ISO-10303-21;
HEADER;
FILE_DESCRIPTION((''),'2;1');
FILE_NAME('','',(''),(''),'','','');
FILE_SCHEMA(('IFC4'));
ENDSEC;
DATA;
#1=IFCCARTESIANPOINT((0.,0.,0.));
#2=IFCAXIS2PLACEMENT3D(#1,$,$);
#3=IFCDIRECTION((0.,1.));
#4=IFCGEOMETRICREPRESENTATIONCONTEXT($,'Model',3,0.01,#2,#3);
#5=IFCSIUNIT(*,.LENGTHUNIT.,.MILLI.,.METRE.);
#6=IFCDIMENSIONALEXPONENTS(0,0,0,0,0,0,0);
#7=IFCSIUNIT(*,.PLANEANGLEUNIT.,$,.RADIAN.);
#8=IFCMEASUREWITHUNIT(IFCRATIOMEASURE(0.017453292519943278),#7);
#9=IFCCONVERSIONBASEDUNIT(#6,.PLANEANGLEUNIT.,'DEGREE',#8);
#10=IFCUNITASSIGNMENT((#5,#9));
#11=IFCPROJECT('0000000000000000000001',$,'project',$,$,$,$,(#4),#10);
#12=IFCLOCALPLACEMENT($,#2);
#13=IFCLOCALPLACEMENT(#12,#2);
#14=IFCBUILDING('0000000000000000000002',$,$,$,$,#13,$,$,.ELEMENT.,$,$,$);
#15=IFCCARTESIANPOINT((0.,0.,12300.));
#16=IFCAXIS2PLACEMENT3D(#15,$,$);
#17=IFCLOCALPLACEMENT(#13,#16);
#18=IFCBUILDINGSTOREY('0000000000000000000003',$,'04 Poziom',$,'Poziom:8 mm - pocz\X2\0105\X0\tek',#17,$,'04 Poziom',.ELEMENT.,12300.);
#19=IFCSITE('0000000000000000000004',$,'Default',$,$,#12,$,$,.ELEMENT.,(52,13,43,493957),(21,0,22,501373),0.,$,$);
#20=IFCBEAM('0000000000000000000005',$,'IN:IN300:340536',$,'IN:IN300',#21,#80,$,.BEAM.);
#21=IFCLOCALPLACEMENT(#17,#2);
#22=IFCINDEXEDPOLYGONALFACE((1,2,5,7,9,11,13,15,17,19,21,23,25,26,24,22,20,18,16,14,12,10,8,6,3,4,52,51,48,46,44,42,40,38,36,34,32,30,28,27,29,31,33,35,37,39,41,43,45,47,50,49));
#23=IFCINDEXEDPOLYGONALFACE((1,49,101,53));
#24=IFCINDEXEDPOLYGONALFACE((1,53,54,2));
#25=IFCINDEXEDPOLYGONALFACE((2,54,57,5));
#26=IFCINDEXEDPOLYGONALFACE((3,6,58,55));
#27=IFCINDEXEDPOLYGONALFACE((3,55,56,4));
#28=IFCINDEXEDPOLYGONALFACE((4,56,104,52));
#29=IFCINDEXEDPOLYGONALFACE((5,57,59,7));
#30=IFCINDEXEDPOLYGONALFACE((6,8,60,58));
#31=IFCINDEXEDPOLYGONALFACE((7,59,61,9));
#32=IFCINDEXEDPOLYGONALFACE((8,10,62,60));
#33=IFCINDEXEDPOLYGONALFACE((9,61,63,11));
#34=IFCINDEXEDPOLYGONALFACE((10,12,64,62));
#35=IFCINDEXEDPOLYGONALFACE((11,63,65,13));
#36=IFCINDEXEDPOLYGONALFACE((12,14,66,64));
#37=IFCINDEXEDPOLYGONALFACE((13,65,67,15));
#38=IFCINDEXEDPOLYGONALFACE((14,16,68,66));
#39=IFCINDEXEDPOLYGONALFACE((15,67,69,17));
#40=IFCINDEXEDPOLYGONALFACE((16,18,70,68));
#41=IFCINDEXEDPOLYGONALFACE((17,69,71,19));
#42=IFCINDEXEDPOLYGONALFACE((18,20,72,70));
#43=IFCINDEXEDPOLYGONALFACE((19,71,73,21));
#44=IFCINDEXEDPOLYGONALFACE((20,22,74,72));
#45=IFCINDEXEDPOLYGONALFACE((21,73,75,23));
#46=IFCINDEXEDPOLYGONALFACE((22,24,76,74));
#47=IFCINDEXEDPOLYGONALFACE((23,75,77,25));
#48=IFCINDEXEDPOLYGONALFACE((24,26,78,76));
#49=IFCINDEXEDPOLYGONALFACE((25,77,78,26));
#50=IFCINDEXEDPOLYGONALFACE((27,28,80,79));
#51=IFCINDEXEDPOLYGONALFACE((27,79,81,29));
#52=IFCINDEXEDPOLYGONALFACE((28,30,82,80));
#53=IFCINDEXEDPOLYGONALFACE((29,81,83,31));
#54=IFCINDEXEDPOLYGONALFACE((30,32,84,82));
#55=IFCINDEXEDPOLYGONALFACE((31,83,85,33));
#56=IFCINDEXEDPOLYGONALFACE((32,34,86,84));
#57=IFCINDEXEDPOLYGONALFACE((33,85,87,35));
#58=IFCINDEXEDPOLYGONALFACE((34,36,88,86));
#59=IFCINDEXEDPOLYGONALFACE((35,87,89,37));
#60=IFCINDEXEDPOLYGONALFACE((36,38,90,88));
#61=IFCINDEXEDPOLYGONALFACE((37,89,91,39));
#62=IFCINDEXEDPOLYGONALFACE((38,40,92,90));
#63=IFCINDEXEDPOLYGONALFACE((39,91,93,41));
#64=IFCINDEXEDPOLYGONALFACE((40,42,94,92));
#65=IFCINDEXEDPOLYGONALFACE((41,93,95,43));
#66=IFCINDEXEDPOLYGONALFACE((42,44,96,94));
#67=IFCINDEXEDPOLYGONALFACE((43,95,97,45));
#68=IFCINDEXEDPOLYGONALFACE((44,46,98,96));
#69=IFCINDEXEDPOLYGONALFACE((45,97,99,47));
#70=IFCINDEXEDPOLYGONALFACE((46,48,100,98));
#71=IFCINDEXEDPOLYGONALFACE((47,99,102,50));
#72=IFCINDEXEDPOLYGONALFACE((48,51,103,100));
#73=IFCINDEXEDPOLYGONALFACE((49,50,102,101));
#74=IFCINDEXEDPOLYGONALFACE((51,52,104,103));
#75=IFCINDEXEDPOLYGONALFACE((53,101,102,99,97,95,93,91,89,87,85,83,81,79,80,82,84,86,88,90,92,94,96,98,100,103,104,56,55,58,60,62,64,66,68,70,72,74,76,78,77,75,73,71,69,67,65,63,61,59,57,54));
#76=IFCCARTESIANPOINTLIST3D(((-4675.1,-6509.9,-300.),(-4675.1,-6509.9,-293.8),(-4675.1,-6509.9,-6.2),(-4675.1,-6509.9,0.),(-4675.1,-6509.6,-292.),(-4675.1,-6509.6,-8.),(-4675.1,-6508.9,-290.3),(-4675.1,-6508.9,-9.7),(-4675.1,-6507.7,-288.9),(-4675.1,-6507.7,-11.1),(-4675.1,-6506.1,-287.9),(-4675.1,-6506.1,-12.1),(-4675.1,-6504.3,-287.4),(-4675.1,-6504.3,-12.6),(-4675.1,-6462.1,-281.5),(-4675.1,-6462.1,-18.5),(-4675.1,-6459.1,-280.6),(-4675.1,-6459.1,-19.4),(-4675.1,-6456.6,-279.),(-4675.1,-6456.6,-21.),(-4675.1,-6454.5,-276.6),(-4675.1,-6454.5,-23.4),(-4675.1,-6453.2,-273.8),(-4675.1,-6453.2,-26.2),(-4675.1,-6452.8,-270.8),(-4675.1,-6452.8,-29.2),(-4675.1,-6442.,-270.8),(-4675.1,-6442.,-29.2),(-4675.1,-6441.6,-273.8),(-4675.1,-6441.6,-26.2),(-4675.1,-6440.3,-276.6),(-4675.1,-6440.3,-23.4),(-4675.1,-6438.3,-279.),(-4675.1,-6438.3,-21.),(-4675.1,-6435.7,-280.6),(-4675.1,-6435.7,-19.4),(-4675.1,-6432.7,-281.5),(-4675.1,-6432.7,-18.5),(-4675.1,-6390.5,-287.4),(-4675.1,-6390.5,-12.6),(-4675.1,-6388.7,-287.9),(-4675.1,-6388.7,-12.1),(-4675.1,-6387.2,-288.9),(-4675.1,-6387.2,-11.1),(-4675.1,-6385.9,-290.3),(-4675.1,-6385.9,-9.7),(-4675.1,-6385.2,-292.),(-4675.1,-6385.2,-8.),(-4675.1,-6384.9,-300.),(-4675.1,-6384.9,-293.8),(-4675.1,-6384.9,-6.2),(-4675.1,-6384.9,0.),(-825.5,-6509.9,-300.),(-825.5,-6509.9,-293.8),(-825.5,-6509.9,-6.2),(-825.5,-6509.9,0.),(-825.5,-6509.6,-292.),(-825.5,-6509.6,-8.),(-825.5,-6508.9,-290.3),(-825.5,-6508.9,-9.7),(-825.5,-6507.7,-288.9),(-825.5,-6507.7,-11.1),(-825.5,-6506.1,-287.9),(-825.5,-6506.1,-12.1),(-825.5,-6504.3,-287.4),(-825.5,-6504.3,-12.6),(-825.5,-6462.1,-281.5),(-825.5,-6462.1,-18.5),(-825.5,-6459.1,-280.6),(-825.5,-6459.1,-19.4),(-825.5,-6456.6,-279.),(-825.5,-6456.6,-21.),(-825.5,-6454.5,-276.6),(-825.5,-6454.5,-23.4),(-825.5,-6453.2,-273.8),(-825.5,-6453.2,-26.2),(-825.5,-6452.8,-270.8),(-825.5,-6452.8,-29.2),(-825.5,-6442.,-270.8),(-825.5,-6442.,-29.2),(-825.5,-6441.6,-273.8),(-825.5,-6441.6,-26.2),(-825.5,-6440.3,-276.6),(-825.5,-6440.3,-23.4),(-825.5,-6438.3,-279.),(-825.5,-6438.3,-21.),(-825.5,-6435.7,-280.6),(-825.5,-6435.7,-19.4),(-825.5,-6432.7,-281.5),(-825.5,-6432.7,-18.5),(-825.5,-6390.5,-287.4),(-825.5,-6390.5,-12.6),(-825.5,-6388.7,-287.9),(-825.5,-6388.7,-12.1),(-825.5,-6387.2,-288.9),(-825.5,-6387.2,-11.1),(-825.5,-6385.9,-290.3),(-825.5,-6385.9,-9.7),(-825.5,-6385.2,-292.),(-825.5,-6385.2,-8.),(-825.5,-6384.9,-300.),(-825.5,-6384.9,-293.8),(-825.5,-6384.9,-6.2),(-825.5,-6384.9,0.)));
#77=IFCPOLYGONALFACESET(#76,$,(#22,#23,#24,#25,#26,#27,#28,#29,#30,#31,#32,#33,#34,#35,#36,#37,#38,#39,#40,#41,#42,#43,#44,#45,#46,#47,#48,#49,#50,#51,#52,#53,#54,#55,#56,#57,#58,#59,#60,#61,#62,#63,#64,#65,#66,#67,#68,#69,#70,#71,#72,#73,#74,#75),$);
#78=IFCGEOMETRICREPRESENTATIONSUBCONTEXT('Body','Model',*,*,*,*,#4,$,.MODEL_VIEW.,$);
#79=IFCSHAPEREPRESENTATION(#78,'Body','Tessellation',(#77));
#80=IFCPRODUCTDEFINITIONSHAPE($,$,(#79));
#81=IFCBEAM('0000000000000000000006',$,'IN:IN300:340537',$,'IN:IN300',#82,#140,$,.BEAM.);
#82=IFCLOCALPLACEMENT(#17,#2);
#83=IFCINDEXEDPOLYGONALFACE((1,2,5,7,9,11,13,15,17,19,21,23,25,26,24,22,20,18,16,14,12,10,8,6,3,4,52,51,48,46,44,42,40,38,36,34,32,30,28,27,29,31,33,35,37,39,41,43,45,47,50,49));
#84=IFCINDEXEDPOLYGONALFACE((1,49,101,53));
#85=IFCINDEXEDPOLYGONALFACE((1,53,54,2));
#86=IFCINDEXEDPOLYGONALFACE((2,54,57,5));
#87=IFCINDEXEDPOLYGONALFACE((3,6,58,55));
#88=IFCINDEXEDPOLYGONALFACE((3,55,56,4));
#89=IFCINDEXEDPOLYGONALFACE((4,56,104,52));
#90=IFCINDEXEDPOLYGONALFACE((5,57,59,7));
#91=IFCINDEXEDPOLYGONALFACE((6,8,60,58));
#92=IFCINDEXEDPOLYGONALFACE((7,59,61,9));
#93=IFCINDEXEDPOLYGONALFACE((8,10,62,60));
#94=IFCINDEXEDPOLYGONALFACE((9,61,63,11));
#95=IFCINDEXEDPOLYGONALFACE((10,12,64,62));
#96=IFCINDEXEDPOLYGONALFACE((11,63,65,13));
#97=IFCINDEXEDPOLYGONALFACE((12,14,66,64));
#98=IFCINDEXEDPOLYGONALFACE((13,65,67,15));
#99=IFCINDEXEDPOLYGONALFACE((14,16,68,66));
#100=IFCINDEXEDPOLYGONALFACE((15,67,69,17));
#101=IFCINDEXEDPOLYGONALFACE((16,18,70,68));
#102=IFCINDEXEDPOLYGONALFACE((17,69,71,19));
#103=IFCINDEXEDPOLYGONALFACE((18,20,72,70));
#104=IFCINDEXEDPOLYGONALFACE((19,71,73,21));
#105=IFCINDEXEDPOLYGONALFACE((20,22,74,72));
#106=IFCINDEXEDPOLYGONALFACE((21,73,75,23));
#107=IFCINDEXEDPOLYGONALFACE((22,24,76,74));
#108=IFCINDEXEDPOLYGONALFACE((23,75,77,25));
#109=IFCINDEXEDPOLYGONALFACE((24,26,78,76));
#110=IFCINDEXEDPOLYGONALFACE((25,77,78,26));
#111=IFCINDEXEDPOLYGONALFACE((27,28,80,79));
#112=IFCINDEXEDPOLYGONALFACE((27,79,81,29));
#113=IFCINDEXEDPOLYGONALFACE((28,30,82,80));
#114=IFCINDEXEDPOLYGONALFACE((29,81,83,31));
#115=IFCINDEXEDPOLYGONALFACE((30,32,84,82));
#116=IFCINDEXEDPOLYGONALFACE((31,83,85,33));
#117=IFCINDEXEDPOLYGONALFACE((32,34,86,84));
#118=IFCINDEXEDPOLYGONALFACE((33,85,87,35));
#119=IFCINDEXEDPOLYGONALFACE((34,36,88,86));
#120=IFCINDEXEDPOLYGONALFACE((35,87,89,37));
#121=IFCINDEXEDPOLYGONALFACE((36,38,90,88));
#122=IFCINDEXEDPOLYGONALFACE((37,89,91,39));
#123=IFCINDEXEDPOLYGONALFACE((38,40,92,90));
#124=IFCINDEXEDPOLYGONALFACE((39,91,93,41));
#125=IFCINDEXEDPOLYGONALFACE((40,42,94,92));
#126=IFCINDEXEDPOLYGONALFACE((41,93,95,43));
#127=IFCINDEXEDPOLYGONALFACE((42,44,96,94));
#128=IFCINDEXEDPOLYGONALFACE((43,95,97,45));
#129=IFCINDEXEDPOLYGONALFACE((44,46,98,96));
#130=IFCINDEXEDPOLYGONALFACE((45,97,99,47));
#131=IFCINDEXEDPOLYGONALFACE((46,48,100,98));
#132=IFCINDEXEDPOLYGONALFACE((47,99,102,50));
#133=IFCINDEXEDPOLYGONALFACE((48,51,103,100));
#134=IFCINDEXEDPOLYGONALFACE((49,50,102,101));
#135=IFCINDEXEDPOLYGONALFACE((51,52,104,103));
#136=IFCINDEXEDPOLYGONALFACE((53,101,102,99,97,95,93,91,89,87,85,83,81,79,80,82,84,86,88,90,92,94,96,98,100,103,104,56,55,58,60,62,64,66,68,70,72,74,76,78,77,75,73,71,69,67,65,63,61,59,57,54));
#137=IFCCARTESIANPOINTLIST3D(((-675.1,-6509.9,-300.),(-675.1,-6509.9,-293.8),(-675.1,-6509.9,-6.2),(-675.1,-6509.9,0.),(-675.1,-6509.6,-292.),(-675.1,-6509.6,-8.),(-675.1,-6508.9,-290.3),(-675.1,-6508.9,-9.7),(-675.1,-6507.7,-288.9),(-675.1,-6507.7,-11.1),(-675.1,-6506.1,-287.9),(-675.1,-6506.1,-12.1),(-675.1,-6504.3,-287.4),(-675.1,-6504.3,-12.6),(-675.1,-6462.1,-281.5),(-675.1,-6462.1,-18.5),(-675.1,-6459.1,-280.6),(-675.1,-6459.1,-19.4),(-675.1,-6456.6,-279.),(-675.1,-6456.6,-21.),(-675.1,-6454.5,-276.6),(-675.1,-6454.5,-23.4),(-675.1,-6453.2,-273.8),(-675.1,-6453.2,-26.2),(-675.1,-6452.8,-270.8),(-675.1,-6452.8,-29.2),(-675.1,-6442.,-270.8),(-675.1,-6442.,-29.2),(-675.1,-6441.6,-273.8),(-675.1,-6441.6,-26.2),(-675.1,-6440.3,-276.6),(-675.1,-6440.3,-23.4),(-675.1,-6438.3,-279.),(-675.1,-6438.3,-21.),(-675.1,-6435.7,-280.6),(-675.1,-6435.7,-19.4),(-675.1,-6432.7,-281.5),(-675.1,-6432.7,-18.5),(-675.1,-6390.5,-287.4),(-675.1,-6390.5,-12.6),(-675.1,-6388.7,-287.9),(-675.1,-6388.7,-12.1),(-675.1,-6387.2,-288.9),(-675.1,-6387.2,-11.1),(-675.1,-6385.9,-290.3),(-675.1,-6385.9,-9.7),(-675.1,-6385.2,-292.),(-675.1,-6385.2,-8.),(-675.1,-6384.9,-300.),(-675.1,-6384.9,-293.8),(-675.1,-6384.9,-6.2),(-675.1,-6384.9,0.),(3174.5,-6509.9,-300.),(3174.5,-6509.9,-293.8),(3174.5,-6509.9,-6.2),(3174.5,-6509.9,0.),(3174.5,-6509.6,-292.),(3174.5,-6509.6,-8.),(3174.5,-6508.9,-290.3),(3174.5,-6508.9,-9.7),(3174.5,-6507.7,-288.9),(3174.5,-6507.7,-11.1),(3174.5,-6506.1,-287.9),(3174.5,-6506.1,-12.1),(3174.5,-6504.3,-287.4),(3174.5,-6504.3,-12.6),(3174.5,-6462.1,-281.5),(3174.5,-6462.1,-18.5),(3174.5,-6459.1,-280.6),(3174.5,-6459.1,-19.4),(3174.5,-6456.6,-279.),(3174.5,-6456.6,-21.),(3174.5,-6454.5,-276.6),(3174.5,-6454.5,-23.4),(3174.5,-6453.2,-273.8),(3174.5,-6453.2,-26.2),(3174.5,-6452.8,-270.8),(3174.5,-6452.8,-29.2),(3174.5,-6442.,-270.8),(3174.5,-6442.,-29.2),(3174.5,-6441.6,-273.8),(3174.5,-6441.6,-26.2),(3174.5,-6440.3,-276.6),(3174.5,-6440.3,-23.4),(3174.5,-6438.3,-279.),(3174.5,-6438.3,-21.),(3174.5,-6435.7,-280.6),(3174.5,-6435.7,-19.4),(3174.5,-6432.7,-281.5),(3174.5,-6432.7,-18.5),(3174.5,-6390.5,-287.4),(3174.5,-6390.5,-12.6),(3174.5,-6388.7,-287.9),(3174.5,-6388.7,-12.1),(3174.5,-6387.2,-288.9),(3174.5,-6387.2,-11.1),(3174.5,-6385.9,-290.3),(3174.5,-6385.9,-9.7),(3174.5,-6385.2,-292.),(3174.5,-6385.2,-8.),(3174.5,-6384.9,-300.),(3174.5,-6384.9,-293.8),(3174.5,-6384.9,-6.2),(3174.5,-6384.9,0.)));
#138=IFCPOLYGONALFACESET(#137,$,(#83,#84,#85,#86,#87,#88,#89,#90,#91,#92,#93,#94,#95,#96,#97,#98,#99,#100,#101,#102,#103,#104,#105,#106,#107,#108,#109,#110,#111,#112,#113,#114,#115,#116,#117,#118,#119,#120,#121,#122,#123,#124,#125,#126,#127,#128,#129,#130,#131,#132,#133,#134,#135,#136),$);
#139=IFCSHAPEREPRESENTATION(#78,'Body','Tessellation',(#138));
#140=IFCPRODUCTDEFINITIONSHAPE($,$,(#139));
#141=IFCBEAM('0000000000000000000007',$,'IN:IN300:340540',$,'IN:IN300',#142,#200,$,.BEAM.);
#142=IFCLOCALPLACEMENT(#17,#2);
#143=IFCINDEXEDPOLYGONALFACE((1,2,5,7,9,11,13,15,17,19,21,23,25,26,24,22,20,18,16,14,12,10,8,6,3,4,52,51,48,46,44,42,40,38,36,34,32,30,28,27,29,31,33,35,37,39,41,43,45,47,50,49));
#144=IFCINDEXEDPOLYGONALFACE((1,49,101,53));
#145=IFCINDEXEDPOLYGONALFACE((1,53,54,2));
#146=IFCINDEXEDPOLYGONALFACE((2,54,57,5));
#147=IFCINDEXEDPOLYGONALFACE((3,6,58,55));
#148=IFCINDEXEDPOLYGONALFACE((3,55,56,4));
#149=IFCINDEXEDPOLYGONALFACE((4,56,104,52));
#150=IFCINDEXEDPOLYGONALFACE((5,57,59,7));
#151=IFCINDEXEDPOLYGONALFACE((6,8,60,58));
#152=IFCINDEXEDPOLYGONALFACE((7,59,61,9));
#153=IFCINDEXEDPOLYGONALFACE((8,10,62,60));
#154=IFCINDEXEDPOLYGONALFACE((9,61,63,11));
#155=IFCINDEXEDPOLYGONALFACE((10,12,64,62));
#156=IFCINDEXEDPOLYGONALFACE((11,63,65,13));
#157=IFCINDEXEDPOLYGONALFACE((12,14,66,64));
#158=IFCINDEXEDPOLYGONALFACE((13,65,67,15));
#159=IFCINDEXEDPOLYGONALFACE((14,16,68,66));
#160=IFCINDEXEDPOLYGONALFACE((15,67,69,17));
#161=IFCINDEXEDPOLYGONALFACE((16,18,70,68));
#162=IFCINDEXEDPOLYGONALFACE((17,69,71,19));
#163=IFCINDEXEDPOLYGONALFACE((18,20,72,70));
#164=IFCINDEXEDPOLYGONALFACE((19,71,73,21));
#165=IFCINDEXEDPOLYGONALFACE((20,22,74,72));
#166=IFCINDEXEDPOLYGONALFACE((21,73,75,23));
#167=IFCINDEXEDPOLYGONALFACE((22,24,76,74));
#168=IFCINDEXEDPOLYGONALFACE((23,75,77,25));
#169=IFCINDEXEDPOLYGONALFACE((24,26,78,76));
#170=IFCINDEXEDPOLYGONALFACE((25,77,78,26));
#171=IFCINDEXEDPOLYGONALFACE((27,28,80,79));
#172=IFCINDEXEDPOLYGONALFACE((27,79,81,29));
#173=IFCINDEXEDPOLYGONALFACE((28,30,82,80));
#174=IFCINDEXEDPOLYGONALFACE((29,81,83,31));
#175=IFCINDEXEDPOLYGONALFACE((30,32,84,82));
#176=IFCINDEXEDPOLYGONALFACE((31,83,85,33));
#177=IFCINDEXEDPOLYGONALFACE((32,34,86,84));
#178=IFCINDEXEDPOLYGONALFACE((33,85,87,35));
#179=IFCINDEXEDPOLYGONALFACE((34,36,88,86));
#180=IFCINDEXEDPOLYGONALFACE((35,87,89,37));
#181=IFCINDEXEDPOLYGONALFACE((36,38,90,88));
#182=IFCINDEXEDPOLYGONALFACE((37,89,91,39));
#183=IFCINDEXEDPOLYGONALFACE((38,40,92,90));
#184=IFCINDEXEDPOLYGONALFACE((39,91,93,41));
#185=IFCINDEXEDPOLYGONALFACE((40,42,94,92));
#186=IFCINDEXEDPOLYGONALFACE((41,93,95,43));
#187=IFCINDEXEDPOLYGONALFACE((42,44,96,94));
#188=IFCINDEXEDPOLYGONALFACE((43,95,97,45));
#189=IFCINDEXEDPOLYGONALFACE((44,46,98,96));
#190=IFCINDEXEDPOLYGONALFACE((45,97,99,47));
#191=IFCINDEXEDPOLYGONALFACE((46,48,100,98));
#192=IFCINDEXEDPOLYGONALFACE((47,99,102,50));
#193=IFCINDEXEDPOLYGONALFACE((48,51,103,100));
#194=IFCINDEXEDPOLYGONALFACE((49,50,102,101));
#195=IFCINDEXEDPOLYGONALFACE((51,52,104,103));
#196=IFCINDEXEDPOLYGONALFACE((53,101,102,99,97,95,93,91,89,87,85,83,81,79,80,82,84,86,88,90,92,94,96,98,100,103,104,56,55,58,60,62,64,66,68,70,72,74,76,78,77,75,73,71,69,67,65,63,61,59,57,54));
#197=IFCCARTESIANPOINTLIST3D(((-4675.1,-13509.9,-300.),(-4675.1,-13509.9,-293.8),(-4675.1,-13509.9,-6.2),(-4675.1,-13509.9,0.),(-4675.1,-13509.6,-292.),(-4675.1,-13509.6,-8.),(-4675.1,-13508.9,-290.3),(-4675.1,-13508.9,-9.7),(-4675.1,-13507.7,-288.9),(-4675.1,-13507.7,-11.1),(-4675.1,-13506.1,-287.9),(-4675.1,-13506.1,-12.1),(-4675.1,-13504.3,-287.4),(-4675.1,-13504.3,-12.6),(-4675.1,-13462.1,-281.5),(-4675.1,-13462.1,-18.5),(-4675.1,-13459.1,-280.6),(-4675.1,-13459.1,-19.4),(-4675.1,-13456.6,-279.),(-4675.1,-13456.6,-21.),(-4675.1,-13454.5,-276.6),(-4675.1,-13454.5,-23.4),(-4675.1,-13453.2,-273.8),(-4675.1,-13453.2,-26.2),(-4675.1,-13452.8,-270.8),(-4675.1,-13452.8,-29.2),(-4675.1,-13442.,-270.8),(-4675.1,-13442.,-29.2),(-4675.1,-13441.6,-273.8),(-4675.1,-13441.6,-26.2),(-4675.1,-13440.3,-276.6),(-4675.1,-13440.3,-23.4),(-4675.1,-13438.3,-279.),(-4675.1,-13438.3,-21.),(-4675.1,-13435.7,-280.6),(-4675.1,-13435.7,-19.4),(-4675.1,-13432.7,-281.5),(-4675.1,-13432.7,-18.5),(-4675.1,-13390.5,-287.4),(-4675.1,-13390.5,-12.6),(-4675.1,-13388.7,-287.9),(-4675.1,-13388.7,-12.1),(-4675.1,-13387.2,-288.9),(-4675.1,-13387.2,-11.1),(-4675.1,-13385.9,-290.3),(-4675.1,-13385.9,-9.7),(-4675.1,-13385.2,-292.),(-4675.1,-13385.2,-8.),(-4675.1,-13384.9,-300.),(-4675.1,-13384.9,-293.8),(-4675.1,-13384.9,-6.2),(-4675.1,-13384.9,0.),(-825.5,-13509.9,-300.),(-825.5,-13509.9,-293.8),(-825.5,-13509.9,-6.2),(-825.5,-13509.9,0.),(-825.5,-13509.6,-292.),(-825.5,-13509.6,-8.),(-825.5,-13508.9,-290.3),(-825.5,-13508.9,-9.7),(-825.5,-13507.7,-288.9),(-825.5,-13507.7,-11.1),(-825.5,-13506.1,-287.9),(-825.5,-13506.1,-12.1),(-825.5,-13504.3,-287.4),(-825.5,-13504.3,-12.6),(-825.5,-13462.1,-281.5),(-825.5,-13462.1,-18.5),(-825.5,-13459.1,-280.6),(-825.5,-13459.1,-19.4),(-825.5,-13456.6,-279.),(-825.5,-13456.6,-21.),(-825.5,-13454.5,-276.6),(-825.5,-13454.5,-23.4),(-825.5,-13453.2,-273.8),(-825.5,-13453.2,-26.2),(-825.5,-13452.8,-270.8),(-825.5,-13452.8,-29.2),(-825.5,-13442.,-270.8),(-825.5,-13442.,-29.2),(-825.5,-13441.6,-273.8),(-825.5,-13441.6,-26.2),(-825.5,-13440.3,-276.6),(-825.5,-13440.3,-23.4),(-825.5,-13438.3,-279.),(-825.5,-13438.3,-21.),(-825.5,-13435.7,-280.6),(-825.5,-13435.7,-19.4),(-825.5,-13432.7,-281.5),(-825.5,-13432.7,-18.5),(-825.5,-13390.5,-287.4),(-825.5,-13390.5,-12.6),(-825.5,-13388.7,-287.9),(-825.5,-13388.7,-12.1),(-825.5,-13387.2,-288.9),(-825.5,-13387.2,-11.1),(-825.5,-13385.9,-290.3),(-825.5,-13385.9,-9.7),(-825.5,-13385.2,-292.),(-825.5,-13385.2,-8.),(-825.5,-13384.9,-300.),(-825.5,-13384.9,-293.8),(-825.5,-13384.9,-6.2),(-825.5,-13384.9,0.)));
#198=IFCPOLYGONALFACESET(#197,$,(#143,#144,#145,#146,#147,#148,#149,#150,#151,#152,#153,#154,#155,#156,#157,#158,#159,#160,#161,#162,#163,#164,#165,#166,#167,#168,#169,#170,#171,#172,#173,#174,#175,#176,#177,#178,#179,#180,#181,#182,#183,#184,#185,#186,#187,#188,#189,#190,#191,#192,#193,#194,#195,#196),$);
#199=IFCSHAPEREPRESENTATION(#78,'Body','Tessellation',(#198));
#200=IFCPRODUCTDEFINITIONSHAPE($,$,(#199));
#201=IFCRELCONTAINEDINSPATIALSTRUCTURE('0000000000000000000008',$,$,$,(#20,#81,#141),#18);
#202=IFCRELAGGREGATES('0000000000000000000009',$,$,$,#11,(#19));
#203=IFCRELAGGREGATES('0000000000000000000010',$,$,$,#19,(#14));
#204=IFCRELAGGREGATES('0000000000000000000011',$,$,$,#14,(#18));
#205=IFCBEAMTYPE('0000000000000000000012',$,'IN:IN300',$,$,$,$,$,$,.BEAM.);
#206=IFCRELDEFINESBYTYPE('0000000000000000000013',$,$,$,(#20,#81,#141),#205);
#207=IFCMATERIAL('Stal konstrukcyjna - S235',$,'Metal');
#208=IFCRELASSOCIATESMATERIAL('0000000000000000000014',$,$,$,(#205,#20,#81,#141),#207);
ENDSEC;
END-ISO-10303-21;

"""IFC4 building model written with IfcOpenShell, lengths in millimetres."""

from ifc_helpers import new_model, entity, si_unit, converted_unit, direction, frame, origin, place, context, subcontext, project, spatial, line, arc, indexed_curve, outline, extrude, source, transform, mapped, material, type_object, type_shapes, element, save


model = new_model("IFC4")

# Units and contexts
model_context = context("Model", 3, precision=0.01, world=origin(), true_north=direction((0.0, 1.0)))
body_context = subcontext(model_context, "Body", "Model", "MODEL_VIEW")
ifc_project = project(units=[si_unit("LENGTHUNIT", "METRE", prefix="MILLI"), converted_unit("PLANEANGLEUNIT", "DEGREE", entity("IfcRatioMeasure", 0.017453292519943278), si_unit("PLANEANGLEUNIT", "RADIAN"), dimensions=[0, 0, 0, 0, 0, 0, 0])], contexts=[model_context])

# Site, building, storey
site_placement = place(None, origin())
site = spatial("IfcSite", under=ifc_project, at=site_placement, Name="Default", CompositionType="ELEMENT", RefLatitude=(52, 13, 43, 493957), RefLongitude=(21, 0, 22, 501373), RefElevation=0.0)
building_placement = place(site_placement, origin())
building = spatial("IfcBuilding", under=site, at=building_placement, CompositionType="ELEMENT")
storey_placement = place(building_placement, frame((0.0, 0.0, 12300.0)))
storey = spatial("IfcBuildingStorey", under=building, at=storey_placement, Name="04 Poziom", ObjectType="Poziom:8 mm - początek", LongName="04 Poziom", CompositionType="ELEMENT", Elevation=12300.0)

# Shared definitions
ifc_material = material(Name="Stal konstrukcyjna - S235", Category="Metal")

# Beams
beam_type_1 = type_object("IfcBeamType", Name="IN:IN300", PredefinedType="BEAM", material=ifc_material)
shared_shape_1 = source(origin(), body_context, "Body", "SweptSolid", [
    extrude(outline(indexed_curve([(143.8, -62.5), (150.0, -62.5), (150.0, 62.5), (143.8, 62.5), (139.6, 60.9), (137.4, 56.9), (131.5, 14.7), (127.9, 8.1), (120.8, 5.4), (-120.8, 5.4), (-127.9, 8.1), (-131.5, 14.7), (-137.4, 56.9), (-139.6, 60.9), (-143.8, 62.5), (-150.0, 62.5), (-150.0, -62.5), (-143.8, -62.5), (-139.6, -60.9), (-137.4, -56.9), (-131.5, -14.7), (-127.9, -8.1), (-120.8, -5.4), (120.8, -5.4), (127.9, -8.1), (131.5, -14.7), (137.4, -56.9), (139.6, -60.9)], segments=[line(1, 2, 3, 4), arc(4, 5, 6), line(6, 7), arc(7, 8, 9), line(9, 10), arc(10, 11, 12), line(12, 13), arc(13, 14, 15), line(15, 16, 17, 18), arc(18, 19, 20), line(20, 21), arc(21, 22, 23), line(23, 24), arc(24, 25, 26), line(26, 27), arc(27, 28, 1)], self_intersect=False)), frame((-1924.8, 0.0, 0.0), z_axis=(1.0, 0.0, 0.0), x_axis=(0.0, 0.0, -1.0)), (0.0, 0.0, 1.0), 3849.6),
])
type_shapes(beam_type_1, [shared_shape_1])
for number, where, name in (
    (1, (-2750.3, -6447.4, -150.0), "IN:IN300:340536"),
    (2, (1249.7, -6447.4, -150.0), "IN:IN300:340537"),
    (3, (-2750.3, -13447.4, -150.0), "IN:IN300:340540"),
):
    element("IfcBeam", number, at=place(storey_placement, frame(where)), inside=storey, type_object=beam_type_1, material=ifc_material, Name=name, ObjectType="IN:IN300", PredefinedType="BEAM", context=body_context, shape_type="MappedRepresentation", body=[
        mapped(shared_shape_1, transform((0.0, 0.0, 0.0), scale=1.0)),
    ])

save(model, "model.ifc")
